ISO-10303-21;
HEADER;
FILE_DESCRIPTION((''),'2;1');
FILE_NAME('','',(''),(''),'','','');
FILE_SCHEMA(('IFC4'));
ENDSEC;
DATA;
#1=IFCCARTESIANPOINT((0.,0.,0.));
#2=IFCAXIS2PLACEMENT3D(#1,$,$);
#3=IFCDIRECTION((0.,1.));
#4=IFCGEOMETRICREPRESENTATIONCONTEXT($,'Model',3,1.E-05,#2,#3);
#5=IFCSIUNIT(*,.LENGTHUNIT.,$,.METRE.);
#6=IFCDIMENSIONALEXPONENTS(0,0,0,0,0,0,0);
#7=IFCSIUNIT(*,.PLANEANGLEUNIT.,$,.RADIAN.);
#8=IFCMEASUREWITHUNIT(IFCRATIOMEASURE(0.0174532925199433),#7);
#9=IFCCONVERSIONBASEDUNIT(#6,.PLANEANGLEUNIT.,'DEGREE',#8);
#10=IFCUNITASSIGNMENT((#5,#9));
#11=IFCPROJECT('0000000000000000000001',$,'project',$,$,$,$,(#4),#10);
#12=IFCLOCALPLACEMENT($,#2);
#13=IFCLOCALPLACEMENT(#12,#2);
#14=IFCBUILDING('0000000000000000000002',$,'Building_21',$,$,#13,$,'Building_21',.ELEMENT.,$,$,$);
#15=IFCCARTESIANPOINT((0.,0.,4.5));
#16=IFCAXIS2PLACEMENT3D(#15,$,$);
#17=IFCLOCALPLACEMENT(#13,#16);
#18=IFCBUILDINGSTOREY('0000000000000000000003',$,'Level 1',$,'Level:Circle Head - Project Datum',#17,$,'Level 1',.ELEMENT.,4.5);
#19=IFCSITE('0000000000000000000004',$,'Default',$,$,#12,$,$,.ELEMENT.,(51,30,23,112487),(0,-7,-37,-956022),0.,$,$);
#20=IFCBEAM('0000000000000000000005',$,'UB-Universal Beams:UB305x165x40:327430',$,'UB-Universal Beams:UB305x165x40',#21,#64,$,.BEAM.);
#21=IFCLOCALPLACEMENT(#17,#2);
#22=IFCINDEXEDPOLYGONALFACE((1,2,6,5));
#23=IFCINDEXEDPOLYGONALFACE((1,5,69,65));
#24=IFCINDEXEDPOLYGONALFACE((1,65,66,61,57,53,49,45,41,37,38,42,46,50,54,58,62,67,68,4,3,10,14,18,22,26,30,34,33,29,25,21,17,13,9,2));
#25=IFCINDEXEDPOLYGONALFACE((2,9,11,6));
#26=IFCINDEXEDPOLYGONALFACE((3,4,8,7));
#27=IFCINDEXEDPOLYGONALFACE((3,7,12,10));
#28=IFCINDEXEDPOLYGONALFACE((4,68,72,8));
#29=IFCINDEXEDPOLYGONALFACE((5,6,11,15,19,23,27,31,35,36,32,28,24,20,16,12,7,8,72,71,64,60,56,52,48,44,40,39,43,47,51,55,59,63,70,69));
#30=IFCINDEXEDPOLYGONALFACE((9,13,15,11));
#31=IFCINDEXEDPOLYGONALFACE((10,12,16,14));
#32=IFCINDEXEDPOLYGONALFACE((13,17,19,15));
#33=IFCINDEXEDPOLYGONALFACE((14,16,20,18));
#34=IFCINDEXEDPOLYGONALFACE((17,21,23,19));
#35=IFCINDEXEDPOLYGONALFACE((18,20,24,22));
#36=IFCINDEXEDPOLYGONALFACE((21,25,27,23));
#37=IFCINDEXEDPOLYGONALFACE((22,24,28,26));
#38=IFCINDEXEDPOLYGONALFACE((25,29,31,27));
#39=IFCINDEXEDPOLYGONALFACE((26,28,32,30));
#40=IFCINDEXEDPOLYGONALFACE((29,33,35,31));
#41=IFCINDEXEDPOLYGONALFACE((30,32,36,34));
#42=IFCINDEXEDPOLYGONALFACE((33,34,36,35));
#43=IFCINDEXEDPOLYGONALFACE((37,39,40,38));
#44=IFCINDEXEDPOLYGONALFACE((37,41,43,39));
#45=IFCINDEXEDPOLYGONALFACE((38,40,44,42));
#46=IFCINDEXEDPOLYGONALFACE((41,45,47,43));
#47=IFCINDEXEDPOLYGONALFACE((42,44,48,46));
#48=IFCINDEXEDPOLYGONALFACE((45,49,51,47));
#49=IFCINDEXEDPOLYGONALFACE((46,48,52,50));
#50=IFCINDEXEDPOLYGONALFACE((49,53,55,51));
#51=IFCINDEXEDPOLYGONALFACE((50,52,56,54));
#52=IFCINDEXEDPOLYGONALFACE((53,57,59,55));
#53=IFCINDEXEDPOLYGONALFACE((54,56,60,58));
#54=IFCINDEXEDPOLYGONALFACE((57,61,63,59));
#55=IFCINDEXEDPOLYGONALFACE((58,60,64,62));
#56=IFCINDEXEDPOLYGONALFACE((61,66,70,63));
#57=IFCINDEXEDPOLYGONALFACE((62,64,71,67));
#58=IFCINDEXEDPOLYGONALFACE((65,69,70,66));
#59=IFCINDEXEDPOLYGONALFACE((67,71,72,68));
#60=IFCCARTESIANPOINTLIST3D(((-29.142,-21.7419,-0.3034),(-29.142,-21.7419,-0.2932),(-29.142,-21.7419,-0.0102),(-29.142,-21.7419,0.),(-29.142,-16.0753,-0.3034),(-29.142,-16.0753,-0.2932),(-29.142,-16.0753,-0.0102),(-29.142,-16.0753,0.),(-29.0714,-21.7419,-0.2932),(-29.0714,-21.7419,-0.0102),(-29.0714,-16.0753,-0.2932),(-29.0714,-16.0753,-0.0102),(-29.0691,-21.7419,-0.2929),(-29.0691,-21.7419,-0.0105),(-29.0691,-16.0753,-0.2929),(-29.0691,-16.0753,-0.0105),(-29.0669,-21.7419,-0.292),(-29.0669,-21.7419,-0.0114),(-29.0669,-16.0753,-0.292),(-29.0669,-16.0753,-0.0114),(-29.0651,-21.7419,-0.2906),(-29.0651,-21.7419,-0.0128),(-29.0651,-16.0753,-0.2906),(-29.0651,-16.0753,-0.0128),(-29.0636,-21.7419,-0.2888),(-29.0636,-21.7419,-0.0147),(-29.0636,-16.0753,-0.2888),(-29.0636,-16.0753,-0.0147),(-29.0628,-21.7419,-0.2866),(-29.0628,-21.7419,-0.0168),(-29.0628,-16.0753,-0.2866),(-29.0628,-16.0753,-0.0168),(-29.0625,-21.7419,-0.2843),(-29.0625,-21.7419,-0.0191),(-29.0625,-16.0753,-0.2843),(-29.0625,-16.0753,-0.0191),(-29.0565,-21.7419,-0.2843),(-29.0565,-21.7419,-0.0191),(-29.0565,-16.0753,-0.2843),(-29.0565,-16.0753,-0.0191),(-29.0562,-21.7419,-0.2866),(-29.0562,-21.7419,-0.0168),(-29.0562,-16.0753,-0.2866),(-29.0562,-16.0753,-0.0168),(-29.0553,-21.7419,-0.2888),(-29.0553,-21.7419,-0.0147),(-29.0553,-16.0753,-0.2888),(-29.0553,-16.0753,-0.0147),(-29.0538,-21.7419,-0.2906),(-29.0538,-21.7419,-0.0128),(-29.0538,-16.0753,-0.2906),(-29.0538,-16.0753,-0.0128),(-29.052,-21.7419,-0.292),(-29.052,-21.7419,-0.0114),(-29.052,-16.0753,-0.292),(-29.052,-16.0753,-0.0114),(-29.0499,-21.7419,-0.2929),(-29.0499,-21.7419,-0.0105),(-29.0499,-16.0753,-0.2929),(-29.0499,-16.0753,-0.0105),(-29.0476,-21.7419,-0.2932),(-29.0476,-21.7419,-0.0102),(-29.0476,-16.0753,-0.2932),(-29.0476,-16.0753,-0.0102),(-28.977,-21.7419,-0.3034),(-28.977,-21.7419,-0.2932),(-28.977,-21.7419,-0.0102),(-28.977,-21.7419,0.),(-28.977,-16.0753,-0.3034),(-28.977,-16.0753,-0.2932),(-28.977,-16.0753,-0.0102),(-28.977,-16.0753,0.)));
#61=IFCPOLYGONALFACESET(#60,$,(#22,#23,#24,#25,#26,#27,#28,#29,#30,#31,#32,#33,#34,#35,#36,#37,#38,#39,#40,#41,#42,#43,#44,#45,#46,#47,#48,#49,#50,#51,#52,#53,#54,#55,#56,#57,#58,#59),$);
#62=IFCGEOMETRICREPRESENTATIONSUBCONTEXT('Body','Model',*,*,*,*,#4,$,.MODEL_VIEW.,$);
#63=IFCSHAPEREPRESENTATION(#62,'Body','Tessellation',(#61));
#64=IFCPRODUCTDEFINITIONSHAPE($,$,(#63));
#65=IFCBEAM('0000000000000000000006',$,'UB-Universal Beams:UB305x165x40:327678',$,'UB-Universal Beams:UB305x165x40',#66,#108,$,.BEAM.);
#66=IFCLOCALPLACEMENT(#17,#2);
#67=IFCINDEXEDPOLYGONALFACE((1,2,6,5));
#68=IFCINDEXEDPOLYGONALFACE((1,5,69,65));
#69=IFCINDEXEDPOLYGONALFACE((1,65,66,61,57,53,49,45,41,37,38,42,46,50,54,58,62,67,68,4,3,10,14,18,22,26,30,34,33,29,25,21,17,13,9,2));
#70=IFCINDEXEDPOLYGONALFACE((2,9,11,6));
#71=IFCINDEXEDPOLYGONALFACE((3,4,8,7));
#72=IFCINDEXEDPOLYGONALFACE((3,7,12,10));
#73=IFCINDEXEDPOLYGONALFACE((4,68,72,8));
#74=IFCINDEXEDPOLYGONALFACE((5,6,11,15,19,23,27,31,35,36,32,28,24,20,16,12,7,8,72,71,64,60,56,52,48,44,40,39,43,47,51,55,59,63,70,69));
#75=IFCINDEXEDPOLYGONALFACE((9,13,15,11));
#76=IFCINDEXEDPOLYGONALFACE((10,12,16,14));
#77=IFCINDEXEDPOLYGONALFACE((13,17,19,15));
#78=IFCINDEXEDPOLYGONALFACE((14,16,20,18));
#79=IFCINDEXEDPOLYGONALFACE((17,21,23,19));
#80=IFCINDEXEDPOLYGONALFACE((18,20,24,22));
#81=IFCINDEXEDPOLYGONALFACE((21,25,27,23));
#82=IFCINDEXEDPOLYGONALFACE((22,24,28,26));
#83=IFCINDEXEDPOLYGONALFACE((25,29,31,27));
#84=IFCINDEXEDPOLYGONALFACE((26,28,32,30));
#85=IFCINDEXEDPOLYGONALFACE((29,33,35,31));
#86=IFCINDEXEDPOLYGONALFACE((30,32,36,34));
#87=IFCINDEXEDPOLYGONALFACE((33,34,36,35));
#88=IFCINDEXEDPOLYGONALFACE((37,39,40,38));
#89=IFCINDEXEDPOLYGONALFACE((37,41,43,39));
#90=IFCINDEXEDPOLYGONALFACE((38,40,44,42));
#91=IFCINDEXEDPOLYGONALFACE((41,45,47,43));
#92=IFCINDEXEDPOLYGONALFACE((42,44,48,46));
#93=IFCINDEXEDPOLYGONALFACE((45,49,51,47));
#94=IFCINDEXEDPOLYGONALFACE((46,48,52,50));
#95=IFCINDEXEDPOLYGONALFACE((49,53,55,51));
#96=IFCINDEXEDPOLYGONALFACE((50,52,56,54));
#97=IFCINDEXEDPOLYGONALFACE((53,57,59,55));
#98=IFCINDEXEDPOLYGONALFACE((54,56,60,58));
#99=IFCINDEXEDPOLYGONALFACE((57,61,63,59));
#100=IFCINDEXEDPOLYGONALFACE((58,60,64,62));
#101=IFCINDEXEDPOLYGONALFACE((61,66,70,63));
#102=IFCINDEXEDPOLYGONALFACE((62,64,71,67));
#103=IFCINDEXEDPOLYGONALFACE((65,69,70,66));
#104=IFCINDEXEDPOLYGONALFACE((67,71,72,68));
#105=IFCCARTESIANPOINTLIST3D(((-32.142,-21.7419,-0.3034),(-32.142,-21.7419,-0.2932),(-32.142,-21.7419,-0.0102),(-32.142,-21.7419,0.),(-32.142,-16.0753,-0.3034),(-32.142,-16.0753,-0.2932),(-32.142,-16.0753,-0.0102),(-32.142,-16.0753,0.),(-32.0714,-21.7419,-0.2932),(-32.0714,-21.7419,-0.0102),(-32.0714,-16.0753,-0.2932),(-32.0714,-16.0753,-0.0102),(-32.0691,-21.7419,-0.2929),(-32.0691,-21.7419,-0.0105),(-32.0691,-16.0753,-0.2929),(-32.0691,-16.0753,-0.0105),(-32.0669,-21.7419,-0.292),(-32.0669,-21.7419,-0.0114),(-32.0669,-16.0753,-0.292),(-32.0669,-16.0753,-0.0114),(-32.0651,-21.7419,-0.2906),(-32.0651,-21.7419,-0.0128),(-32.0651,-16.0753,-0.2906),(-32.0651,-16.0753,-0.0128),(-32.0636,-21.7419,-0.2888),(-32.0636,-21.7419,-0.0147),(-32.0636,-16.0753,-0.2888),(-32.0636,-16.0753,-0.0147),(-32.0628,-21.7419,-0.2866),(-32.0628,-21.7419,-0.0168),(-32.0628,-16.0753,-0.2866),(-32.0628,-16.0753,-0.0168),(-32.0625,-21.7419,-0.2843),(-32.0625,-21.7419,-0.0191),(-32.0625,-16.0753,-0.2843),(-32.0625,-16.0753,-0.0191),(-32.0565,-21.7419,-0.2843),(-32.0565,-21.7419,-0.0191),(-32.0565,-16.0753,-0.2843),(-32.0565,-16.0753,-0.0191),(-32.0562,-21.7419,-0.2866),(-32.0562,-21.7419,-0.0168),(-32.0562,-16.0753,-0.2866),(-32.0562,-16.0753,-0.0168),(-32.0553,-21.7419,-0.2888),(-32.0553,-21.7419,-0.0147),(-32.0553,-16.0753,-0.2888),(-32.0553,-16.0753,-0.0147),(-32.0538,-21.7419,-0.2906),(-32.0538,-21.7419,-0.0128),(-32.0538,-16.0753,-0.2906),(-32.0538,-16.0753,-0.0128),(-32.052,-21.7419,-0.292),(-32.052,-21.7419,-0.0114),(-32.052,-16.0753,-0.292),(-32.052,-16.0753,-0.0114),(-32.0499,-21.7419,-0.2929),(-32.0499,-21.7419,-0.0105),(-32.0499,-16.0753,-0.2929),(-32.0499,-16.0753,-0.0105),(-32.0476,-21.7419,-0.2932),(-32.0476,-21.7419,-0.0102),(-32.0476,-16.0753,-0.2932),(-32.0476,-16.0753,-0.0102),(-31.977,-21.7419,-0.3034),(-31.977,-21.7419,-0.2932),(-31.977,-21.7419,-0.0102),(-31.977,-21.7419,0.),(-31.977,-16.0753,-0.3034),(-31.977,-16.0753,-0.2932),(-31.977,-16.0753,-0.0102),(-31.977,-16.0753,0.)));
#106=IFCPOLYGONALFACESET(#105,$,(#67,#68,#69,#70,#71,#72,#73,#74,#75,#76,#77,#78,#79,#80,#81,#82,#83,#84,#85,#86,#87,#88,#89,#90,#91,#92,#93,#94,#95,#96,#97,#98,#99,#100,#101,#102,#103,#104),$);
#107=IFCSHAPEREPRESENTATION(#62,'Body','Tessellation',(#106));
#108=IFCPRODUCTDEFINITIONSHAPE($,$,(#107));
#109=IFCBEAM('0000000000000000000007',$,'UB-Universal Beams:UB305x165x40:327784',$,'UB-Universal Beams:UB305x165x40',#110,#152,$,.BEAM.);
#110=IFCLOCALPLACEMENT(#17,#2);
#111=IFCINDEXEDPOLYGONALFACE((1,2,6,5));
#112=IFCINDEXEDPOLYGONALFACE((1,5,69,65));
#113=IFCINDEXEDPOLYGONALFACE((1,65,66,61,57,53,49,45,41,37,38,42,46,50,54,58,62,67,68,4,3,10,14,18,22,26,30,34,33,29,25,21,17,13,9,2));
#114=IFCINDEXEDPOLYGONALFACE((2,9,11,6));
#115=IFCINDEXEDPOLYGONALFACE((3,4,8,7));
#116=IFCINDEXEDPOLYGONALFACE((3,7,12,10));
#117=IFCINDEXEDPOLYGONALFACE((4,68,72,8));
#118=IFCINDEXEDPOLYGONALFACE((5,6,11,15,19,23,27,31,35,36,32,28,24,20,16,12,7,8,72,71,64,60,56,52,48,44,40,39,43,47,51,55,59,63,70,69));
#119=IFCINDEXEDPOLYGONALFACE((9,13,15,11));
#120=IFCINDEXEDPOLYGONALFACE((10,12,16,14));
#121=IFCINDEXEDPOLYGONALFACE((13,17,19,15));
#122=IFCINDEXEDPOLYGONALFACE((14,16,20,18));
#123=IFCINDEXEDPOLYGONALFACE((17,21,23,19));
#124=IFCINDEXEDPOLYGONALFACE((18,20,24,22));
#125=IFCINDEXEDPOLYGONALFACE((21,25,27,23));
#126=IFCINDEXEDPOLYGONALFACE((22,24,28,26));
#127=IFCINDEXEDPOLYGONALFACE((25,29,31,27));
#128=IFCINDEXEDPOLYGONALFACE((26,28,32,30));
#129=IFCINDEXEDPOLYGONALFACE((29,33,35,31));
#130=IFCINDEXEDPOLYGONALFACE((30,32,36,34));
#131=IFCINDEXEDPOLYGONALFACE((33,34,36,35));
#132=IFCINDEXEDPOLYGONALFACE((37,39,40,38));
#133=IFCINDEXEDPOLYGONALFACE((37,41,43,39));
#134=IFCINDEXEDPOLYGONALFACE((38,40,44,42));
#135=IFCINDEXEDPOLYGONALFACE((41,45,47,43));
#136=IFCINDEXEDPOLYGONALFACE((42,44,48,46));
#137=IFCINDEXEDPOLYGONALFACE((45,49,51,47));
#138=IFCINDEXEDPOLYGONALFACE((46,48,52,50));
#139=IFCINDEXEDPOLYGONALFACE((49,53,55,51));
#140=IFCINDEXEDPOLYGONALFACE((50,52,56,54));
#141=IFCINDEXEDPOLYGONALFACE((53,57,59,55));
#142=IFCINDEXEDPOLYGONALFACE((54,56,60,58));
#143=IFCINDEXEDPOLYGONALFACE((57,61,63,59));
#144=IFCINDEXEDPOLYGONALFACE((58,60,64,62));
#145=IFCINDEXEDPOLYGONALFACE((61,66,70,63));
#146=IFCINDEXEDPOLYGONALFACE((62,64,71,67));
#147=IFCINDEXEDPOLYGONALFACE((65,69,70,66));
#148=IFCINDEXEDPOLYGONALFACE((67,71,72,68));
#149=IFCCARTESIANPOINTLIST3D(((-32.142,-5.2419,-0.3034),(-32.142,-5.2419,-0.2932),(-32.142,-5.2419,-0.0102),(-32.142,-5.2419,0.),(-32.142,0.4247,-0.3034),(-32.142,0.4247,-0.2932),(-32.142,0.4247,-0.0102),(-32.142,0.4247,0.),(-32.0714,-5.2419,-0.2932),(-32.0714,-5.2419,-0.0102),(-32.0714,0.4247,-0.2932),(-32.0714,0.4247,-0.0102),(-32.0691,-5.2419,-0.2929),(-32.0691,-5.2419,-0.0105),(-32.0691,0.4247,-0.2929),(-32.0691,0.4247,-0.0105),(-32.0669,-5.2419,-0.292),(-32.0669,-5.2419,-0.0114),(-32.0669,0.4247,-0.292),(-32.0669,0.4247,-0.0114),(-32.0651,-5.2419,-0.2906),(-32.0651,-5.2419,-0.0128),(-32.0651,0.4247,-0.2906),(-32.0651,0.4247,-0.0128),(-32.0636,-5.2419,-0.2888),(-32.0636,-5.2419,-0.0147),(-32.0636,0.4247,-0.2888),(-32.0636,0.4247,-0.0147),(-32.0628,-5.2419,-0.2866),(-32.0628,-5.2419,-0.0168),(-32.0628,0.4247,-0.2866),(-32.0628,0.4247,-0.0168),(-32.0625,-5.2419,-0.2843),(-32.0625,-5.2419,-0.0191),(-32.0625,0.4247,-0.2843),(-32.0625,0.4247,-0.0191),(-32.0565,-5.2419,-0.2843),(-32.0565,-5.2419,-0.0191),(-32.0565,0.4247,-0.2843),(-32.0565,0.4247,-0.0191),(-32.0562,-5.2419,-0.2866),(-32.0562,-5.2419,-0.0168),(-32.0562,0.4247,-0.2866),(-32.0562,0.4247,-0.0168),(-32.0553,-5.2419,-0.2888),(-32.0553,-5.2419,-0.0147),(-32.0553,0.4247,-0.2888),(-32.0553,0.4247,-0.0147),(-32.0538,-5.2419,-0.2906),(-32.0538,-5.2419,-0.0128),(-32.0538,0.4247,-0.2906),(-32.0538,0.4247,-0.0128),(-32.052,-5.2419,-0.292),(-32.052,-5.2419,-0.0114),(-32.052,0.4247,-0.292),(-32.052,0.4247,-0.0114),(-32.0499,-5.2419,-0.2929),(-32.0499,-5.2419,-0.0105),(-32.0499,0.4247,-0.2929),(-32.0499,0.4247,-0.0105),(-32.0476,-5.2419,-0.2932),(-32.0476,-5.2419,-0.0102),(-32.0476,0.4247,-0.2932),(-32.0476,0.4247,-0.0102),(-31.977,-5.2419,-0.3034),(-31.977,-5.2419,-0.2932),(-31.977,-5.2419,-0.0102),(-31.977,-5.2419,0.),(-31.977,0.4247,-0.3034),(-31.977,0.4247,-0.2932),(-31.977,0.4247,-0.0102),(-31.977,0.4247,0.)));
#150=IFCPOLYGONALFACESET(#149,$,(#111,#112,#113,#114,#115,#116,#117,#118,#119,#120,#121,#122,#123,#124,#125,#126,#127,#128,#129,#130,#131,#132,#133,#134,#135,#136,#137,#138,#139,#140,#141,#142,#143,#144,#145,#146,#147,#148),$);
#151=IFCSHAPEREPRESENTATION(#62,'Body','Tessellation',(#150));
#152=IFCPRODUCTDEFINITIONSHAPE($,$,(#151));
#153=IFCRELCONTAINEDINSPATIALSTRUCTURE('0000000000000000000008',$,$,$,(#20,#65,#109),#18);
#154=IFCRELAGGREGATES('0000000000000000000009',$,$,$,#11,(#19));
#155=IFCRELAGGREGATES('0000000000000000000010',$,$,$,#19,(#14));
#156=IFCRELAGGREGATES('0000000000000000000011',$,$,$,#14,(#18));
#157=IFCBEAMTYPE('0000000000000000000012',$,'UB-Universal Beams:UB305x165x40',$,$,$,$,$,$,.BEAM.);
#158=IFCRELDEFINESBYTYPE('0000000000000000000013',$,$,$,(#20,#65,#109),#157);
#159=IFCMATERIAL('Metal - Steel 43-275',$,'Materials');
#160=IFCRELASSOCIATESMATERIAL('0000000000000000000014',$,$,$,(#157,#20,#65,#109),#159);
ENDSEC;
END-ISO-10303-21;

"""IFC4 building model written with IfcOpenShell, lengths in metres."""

from ifc_helpers import new_model, entity, si_unit, converted_unit, direction, frame, frame_2d, origin, place, context, subcontext, project, spatial, polyline, circle_curve, parameter, trimmed, segment, composite_curve, i_section, outline, extrude, source, transform, mapped, material, material_profile, profile_set, profile_usage, type_object, type_shapes, element, save


model = new_model("IFC4")

# Units and contexts
model_context = context("Model", 3, precision=1e-05, world=origin(), true_north=direction((0.0, 1.0)))
body_context = subcontext(model_context, "Body", "Model", "MODEL_VIEW")
ifc_project = project(units=[si_unit("LENGTHUNIT", "METRE"), converted_unit("PLANEANGLEUNIT", "DEGREE", entity("IfcRatioMeasure", 0.0174532925199433), si_unit("PLANEANGLEUNIT", "RADIAN"), dimensions=[0, 0, 0, 0, 0, 0, 0])], contexts=[model_context])

# Site, building, storey
site_placement = place(None, origin())
site = spatial("IfcSite", under=ifc_project, at=site_placement, Name="Default", CompositionType="ELEMENT", RefLatitude=(51, 30, 23, 112487), RefLongitude=(0, -7, -37, -956022), RefElevation=0.0)
building_placement = place(site_placement, origin())
building = spatial("IfcBuilding", under=site, at=building_placement, Name="Building_21", LongName="Building_21", CompositionType="ELEMENT")
storey_placement = place(building_placement, frame((0.0, 0.0, 4.5)))
storey = spatial("IfcBuildingStorey", under=building, at=storey_placement, Name="Level 1", ObjectType="Level:Circle Head - Project Datum", LongName="Level 1", CompositionType="ELEMENT", Elevation=4.5)

# Shared definitions
ifc_material_1 = material(Name="Metal - Steel 43-275", Category="Materials")

# Beams
ifc_material_profile_1 = material_profile(ifc_material_1, outline(composite_curve([segment(polyline([(0.0119, -0.1415, 0.0), (0.0825, -0.1415, 0.0)]), True, "CONTINUOUS"), segment(polyline([(0.0825, -0.1415, 0.0), (0.0825, -0.1517, 0.0)]), True, "CONTINUOUS"), segment(polyline([(0.0825, -0.1517, 0.0), (-0.0825, -0.1517, 0.0)]), True, "CONTINUOUS"), segment(polyline([(-0.0825, -0.1517, 0.0), (-0.0825, -0.1415, 0.0)]), True, "CONTINUOUS"), segment(polyline([(-0.0825, -0.1415, 0.0), (-0.0119, -0.1415, 0.0)]), True, "CONTINUOUS"), segment(trimmed(circle_curve(frame((-0.0119, -0.1326, 0.0), z_axis=(0.0, 0.0, 1.0), x_axis=(-1.0, 0.0, 0.0)), 0.0089), [parameter(90.0)], [parameter(180.0)], True, "PARAMETER"), True, "CONTINUOUS"), segment(polyline([(-0.003, -0.1326, 0.0), (-0.003, 0.1326, 0.0)]), True, "CONTINUOUS"), segment(trimmed(circle_curve(frame((-0.0119, 0.1326, 0.0), z_axis=(0.0, 0.0, 1.0), x_axis=(-1.0, 0.0, 0.0)), 0.0089), [parameter(180.0)], [parameter(270.0)], True, "PARAMETER"), True, "CONTINUOUS"), segment(polyline([(-0.0119, 0.1415, 0.0), (-0.0825, 0.1415, 0.0)]), True, "CONTINUOUS"), segment(polyline([(-0.0825, 0.1415, 0.0), (-0.0825, 0.1517, 0.0)]), True, "CONTINUOUS"), segment(polyline([(-0.0825, 0.1517, 0.0), (0.0825, 0.1517, 0.0)]), True, "CONTINUOUS"), segment(polyline([(0.0825, 0.1517, 0.0), (0.0825, 0.1415, 0.0)]), True, "CONTINUOUS"), segment(polyline([(0.0825, 0.1415, 0.0), (0.0119, 0.1415, 0.0)]), True, "CONTINUOUS"), segment(trimmed(circle_curve(frame((0.0119, 0.1326, 0.0), z_axis=(0.0, 0.0, 1.0), x_axis=(-1.0, 0.0, 0.0)), 0.0089), [parameter(270.0)], [parameter(0.0)], True, "PARAMETER"), True, "CONTINUOUS"), segment(polyline([(0.003, 0.1326, 0.0), (0.003, -0.1326, 0.0)]), True, "CONTINUOUS"), segment(trimmed(circle_curve(frame((0.0119, -0.1326, 0.0), z_axis=(0.0, 0.0, 1.0), x_axis=(-1.0, 0.0, 0.0)), 0.0089), [parameter(0.0)], [parameter(90.0)], True, "PARAMETER"), True, "CONTINUOUS")], self_intersect=False), kind="CURVE"), Name="UB305x165x40")
ifc_material_profile_2 = material_profile(ifc_material_1, outline(composite_curve([segment(polyline([(-1.3346, 0.0825, -0.1415), (-1.3346, 0.0825, -0.1517)]), True, "CONTINUOUS"), segment(polyline([(-1.3346, 0.0825, -0.1517), (-1.3346, -0.0825, -0.1517)]), True, "CONTINUOUS"), segment(polyline([(-1.3346, -0.0825, -0.1517), (-1.3346, -0.0825, -0.1415)]), True, "CONTINUOUS"), segment(polyline([(-1.3346, -0.0825, -0.1415), (-1.3346, -0.003, -0.1415)]), True, "CONTINUOUS"), segment(polyline([(-1.3346, -0.003, -0.1415), (-1.3346, -0.003, 0.1415)]), True, "CONTINUOUS"), segment(polyline([(-1.3346, -0.003, 0.1415), (-1.3346, -0.0825, 0.1415)]), True, "CONTINUOUS"), segment(polyline([(-1.3346, -0.0825, 0.1415), (-1.3346, -0.0825, 0.1517)]), True, "CONTINUOUS"), segment(polyline([(-1.3346, -0.0825, 0.1517), (-1.3346, 0.0825, 0.1517)]), True, "CONTINUOUS"), segment(polyline([(-1.3346, 0.0825, 0.1517), (-1.3346, 0.0825, 0.1415)]), True, "CONTINUOUS"), segment(polyline([(-1.3346, 0.0825, 0.1415), (-1.3346, 0.003, 0.1415)]), True, "CONTINUOUS"), segment(polyline([(-1.3346, 0.003, 0.1415), (-1.3346, 0.003, -0.1415)]), True, "CONTINUOUS"), segment(polyline([(-1.3346, 0.003, -0.1415), (-1.3346, 0.0825, -0.1415)]), True, "CONTINUOUS")], self_intersect=False), kind="CURVE"), Name="UB305x165x40")
ifc_profile_set_1 = profile_set([ifc_material_profile_1, ifc_material_profile_2], Name="UB305x165x40")
beam_type_1 = type_object("IfcBeamType", Name="UB-Universal Beams:UB305x165x40", PredefinedType="BEAM", material=ifc_profile_set_1)
shared_shape_1 = source(origin(), body_context, "Body", "SweptSolid", [
    extrude(i_section(OverallWidth=0.165, OverallDepth=0.3034, WebThickness=0.006, FlangeThickness=0.0102, FilletRadius=0.0089, at=frame_2d((0.0, 0.0), x_axis=(0.0, 1.0))), frame((-2.8333, 0.0, 0.0), z_axis=(1.0, 0.0, 0.0), x_axis=(0.0, 0.0, -1.0)), (0.0, 0.0, 1.0), 5.6666),
])
type_shapes(beam_type_1, [shared_shape_1])
ifc_profile_usage_1 = profile_usage(ifc_profile_set_1, cardinal=8)
beam_1_placement = place(storey_placement, frame((-29.0595, -18.9086, -0.1517), z_axis=(0.0, 0.0, 1.0), x_axis=(0.0, 1.0, 0.0)))
element("IfcBeam", 1, at=beam_1_placement, inside=storey, type_object=beam_type_1, material=ifc_profile_usage_1, Name="UB-Universal Beams:UB305x165x40:327430", ObjectType="UB-Universal Beams:UB305x165x40", PredefinedType="BEAM", context=body_context, shape_type="MappedRepresentation", body=[
    mapped(shared_shape_1, transform((0.0, 0.0, 0.0), scale=1.0)),
])
ifc_profile_usage_2 = profile_usage(ifc_profile_set_1, cardinal=8)
beam_2_placement = place(storey_placement, frame((-32.0595, -18.9086, -0.1517), z_axis=(0.0, 0.0, 1.0), x_axis=(0.0, -1.0, 0.0)))
element("IfcBeam", 2, at=beam_2_placement, inside=storey, type_object=beam_type_1, material=ifc_profile_usage_2, Name="UB-Universal Beams:UB305x165x40:327678", ObjectType="UB-Universal Beams:UB305x165x40", PredefinedType="BEAM", context=body_context, shape_type="MappedRepresentation", body=[
    mapped(shared_shape_1, transform((0.0, 0.0, 0.0), scale=1.0)),
])
ifc_profile_usage_3 = profile_usage(ifc_profile_set_1, cardinal=8)
beam_3_placement = place(storey_placement, frame((-32.0595, -2.4086, -0.1517), z_axis=(0.0, 0.0, 1.0), x_axis=(0.0, -1.0, 0.0)))
element("IfcBeam", 3, at=beam_3_placement, inside=storey, type_object=beam_type_1, material=ifc_profile_usage_3, Name="UB-Universal Beams:UB305x165x40:327784", ObjectType="UB-Universal Beams:UB305x165x40", PredefinedType="BEAM", context=body_context, shape_type="MappedRepresentation", body=[
    mapped(shared_shape_1, transform((0.0, 0.0, 0.0), scale=1.0)),
])

save(model, "model.ifc")
